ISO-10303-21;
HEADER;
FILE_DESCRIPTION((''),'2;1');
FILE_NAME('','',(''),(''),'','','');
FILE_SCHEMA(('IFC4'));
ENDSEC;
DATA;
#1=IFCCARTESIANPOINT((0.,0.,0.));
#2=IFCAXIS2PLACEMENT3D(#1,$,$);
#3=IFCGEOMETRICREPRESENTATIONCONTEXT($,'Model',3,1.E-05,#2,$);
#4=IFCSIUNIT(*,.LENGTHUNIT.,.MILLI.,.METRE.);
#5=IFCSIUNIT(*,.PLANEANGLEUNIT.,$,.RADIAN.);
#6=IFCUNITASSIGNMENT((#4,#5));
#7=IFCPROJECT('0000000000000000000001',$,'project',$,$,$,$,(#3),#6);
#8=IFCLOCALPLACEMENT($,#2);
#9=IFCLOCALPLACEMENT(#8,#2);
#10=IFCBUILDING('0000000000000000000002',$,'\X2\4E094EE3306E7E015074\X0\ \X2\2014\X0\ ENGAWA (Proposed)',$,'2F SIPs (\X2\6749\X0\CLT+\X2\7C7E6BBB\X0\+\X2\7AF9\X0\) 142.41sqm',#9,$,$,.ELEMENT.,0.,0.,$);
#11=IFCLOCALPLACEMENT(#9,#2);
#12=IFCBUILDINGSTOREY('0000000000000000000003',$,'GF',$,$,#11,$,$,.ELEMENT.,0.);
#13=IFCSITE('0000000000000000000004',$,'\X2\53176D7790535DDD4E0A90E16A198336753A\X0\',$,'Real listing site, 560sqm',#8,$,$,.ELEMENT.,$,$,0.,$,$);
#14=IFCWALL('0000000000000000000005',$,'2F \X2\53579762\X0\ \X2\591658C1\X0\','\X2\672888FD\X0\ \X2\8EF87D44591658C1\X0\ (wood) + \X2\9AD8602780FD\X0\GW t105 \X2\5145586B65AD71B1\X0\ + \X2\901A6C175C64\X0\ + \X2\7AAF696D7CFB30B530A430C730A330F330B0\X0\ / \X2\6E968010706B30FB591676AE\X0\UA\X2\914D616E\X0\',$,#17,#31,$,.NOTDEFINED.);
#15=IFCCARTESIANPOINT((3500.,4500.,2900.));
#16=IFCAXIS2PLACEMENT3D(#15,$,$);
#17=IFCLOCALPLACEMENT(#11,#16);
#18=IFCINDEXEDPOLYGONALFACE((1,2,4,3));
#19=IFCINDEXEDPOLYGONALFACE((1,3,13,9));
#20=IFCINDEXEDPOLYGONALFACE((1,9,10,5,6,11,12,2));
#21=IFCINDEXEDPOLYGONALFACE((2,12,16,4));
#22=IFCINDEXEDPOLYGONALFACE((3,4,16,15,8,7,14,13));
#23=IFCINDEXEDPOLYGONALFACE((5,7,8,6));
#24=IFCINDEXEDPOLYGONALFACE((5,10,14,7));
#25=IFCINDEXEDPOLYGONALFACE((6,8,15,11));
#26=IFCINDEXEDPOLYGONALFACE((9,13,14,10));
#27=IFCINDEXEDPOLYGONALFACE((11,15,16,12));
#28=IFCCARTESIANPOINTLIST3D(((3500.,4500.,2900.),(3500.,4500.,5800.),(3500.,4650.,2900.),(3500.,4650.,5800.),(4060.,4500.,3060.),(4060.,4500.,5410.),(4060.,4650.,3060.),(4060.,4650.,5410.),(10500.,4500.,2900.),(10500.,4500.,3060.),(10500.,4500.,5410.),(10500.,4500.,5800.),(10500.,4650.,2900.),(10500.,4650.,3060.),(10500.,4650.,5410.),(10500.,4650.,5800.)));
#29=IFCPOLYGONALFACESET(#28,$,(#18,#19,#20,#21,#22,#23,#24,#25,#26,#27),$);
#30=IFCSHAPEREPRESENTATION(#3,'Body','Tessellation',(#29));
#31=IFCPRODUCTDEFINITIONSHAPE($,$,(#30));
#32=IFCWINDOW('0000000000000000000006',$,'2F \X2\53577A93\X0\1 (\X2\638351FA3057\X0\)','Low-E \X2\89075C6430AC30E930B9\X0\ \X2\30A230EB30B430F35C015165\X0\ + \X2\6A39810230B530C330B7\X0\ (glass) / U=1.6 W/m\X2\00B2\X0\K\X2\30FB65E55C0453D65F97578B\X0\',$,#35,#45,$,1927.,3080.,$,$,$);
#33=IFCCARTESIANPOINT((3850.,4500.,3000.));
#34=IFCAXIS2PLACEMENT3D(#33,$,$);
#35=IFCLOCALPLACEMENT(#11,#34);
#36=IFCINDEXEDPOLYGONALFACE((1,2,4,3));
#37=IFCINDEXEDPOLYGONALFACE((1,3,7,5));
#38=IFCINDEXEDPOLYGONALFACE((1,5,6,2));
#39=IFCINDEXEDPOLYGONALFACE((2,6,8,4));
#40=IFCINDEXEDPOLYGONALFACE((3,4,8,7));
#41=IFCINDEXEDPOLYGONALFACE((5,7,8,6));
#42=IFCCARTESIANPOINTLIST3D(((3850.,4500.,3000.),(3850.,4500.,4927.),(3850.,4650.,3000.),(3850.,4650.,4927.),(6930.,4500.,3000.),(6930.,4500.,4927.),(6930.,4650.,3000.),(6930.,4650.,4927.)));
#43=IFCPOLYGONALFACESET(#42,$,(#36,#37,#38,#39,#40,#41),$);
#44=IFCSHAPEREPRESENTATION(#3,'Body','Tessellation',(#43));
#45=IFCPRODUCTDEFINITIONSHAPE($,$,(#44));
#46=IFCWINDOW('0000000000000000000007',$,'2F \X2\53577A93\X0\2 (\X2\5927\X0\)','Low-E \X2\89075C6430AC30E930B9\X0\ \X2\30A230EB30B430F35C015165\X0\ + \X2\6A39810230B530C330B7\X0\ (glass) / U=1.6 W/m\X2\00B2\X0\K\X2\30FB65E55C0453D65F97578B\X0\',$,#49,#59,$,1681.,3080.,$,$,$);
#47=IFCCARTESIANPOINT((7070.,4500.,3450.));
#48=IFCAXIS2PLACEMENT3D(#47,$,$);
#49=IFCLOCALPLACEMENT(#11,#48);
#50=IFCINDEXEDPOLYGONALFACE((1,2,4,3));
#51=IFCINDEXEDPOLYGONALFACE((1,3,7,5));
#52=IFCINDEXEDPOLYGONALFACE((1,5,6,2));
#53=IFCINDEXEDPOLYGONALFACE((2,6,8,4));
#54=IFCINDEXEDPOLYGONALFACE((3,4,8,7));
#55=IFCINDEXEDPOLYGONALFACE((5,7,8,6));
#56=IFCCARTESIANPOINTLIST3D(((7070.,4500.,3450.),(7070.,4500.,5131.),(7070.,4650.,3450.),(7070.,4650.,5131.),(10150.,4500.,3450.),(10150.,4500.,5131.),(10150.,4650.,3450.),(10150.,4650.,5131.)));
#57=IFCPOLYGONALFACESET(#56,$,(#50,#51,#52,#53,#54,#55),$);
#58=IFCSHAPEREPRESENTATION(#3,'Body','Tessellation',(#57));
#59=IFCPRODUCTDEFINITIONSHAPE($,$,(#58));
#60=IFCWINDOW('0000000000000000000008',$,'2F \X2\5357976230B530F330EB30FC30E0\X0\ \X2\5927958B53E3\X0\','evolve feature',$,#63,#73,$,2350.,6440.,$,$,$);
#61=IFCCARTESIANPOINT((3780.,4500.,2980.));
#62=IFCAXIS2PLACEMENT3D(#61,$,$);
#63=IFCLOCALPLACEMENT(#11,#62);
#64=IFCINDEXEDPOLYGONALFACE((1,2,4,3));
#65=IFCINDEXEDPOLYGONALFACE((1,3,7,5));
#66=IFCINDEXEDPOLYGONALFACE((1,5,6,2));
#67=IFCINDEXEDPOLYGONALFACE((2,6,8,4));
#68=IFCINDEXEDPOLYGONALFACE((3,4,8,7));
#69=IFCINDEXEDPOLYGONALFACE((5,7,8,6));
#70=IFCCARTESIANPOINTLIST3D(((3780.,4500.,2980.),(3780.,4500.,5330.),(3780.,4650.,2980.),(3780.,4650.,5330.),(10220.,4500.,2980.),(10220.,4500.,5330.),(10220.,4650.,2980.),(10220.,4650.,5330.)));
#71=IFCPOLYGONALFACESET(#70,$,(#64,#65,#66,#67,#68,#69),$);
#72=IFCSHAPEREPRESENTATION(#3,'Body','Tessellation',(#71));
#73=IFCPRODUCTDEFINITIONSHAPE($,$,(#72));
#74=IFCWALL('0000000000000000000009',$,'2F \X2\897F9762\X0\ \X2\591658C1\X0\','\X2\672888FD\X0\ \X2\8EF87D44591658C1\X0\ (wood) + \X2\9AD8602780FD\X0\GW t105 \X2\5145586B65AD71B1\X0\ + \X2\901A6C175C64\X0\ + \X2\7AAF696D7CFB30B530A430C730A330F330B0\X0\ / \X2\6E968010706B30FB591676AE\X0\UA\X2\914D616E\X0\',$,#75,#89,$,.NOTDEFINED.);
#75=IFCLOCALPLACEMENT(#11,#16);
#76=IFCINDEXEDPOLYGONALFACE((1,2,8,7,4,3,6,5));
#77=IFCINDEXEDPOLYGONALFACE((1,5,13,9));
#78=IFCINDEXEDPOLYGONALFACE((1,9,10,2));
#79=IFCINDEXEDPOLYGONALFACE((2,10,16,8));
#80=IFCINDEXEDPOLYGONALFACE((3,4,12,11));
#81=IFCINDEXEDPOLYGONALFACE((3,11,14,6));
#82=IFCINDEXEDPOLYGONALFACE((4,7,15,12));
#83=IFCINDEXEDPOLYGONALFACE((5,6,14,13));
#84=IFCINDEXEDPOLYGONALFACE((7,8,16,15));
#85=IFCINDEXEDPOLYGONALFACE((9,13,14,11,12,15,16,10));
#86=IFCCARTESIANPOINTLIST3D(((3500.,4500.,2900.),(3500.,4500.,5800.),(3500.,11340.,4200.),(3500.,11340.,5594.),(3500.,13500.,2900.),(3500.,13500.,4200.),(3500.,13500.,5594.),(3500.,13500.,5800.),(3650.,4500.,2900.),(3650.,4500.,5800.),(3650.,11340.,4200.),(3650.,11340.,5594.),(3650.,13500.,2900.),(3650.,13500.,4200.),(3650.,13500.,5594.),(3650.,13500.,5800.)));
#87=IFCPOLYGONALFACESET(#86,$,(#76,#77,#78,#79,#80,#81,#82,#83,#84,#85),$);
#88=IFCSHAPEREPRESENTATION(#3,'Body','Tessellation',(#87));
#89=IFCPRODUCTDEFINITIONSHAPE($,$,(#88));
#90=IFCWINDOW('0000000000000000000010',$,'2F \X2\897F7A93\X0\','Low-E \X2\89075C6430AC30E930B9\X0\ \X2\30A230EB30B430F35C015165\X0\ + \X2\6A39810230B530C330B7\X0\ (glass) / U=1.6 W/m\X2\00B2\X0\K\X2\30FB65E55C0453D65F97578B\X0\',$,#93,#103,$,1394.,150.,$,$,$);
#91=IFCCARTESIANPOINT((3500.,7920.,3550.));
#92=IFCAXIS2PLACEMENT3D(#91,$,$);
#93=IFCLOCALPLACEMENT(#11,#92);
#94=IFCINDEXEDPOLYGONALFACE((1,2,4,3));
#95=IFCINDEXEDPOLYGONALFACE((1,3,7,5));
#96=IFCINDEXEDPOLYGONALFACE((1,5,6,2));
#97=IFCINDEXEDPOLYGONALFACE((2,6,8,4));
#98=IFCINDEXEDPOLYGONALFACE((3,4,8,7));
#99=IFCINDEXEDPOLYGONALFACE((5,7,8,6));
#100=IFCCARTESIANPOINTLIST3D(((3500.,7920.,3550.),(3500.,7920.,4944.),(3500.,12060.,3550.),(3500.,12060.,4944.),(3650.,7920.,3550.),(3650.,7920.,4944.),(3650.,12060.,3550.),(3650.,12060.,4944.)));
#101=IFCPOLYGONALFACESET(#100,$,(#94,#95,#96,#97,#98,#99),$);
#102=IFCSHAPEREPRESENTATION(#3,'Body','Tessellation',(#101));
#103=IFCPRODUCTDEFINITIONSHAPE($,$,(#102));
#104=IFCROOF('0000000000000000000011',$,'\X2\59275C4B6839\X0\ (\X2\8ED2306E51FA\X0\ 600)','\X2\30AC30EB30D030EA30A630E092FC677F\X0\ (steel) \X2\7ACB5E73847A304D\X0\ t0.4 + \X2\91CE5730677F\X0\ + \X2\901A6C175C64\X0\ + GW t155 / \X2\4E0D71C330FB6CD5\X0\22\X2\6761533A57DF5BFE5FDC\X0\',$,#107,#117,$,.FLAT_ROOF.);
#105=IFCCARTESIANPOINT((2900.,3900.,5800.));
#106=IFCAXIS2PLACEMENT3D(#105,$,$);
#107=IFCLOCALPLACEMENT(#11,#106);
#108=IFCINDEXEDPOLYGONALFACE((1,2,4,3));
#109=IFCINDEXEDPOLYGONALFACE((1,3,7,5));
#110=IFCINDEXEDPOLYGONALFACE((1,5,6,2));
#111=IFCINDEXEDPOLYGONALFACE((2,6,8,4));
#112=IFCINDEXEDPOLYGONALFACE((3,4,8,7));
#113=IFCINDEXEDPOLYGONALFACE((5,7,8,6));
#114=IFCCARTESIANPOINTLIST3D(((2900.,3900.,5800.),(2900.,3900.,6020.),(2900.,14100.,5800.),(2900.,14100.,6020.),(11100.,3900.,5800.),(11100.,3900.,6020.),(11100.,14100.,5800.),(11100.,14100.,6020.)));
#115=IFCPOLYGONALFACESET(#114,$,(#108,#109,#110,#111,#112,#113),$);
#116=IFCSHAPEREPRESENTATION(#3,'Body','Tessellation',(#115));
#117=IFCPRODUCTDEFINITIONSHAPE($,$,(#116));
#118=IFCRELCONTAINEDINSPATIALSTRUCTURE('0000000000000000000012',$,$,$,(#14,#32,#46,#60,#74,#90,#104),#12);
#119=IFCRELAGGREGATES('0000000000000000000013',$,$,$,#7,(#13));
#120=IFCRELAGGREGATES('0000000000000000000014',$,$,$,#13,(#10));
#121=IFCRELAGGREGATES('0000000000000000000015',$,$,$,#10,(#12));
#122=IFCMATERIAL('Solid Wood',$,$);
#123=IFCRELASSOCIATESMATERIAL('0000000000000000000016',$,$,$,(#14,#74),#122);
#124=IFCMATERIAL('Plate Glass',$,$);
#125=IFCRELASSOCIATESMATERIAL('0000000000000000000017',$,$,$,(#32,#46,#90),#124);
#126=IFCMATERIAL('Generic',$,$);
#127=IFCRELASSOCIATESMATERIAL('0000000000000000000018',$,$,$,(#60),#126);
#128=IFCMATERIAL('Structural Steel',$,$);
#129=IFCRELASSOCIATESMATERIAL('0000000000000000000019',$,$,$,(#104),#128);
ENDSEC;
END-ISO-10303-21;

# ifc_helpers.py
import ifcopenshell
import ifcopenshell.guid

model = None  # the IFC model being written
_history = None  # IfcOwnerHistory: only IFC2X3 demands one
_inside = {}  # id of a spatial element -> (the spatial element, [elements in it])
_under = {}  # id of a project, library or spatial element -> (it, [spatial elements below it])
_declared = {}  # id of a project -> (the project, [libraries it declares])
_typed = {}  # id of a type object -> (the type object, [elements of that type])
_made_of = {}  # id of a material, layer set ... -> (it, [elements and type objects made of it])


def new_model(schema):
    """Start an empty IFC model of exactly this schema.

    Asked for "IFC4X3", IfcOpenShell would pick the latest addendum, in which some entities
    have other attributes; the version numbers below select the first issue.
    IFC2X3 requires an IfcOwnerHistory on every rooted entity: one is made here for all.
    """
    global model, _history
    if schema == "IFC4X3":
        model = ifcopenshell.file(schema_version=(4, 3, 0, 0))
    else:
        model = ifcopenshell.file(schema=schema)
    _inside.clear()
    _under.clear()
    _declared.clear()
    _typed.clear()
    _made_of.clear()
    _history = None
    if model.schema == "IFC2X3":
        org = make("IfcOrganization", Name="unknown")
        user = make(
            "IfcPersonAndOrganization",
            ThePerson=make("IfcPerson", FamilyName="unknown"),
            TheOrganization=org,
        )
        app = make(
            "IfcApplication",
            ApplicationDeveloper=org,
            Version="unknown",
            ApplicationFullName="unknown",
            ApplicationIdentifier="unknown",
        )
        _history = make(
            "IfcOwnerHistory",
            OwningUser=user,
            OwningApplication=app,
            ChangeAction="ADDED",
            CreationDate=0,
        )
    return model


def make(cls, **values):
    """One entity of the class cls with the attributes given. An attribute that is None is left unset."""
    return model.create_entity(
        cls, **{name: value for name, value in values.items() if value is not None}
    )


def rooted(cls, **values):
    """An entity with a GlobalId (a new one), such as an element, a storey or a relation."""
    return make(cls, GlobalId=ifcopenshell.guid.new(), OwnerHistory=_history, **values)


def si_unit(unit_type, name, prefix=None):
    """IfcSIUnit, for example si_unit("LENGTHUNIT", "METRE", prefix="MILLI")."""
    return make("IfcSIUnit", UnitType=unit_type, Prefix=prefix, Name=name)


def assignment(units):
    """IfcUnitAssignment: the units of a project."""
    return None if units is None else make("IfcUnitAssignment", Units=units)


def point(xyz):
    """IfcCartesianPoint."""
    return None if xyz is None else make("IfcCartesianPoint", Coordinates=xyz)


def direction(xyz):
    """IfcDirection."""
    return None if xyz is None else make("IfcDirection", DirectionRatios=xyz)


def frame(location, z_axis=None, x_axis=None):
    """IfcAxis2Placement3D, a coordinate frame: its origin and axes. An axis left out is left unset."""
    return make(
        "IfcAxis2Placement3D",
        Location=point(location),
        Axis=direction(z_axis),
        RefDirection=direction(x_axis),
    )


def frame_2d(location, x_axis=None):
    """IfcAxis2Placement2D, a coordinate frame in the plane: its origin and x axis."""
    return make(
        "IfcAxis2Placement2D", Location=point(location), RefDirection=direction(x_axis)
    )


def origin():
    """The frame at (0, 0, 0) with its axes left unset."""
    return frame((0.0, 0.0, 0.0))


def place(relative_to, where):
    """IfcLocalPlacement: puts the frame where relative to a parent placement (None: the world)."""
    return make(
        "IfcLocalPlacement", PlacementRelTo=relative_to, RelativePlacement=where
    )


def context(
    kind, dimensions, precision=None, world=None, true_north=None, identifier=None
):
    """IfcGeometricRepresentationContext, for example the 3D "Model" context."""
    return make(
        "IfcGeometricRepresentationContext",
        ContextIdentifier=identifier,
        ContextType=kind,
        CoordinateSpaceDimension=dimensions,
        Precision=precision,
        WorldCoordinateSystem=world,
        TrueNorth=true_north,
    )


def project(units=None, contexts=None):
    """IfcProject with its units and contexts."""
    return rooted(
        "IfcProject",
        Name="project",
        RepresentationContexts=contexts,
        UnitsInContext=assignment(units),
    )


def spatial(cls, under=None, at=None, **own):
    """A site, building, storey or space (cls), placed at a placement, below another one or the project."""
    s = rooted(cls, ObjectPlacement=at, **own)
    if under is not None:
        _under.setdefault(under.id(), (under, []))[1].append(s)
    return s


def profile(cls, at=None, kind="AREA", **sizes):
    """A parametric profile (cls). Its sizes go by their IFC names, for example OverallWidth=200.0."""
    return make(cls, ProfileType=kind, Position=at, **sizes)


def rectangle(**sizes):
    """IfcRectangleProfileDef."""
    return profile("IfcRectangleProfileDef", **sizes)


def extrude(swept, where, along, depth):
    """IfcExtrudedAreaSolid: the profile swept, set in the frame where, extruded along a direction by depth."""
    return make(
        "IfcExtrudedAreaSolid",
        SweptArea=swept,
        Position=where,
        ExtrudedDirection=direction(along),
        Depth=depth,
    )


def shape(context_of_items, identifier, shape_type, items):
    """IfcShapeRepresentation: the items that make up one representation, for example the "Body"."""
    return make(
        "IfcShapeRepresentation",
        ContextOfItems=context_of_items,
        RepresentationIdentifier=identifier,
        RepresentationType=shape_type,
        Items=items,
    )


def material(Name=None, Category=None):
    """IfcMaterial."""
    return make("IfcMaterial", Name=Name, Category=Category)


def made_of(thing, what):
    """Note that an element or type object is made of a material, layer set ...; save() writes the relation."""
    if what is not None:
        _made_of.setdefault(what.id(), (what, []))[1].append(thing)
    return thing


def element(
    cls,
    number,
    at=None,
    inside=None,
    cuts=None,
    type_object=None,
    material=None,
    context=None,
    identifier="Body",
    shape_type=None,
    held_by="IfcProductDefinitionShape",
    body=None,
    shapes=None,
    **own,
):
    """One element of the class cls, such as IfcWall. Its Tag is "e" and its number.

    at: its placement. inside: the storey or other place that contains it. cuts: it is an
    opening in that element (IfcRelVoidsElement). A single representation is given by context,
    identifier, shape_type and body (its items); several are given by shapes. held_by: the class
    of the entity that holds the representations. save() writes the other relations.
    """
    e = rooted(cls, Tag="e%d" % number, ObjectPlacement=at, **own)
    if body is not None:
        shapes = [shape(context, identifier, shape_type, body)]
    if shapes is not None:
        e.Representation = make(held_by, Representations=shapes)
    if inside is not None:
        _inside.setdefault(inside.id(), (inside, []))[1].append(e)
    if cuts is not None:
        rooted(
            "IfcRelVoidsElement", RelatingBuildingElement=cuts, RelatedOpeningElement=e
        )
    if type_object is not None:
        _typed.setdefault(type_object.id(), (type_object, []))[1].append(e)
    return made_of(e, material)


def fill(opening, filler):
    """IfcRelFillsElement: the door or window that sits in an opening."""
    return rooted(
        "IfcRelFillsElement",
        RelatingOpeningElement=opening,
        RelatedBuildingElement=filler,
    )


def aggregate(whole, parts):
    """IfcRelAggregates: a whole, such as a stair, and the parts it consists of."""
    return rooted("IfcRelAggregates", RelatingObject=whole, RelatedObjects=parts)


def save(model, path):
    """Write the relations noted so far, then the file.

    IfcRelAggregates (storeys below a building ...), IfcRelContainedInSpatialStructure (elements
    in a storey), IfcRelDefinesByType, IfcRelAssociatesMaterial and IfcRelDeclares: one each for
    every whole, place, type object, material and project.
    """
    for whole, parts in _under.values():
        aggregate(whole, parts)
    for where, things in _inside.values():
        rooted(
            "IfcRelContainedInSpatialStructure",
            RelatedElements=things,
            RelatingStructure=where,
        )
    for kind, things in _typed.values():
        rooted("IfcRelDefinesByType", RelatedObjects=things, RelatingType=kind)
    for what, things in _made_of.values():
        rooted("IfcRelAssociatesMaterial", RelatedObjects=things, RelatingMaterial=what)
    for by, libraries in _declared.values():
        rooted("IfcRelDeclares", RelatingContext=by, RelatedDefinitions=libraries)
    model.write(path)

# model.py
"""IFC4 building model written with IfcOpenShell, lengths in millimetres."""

from ifc_helpers import new_model, si_unit, frame, frame_2d, origin, place, context, project, spatial, rectangle, extrude, material, element, fill, save


model = new_model("IFC4")

# Units and contexts
model_context = context("Model", 3, precision=1e-05, world=origin())
ifc_project = project(units=[si_unit("LENGTHUNIT", "METRE", prefix="MILLI"), si_unit("PLANEANGLEUNIT", "RADIAN")], contexts=[model_context])

# Site, building, storey
site_placement = place(None, origin())
site = spatial("IfcSite", under=ifc_project, at=site_placement, Name="北海道川上郡標茶町", ObjectType="Real listing site, 560sqm", CompositionType="ELEMENT", RefElevation=0.0)
building_placement = place(site_placement, origin())
building = spatial("IfcBuilding", under=site, at=building_placement, Name="三代の縁側 — ENGAWA (Proposed)", ObjectType="2F SIPs (杉CLT+籾殻+竹) 142.41sqm", CompositionType="ELEMENT", ElevationOfRefHeight=0.0, ElevationOfTerrain=0.0)
storey_placement = place(building_placement, origin())
storey = spatial("IfcBuildingStorey", under=building, at=storey_placement, Name="GF", CompositionType="ELEMENT", Elevation=0.0)

# Shared definitions
ifc_material_1 = material(Name="Solid Wood")
ifc_material_2 = material(Name="Generic")

# Shared definitions
ifc_material_3 = material(Name="Plate Glass")

# Wall, openings, windows
wall_1_placement = place(storey_placement, frame((3500.0, 4500.0, 2900.0)))
wall_1 = element("IfcWall", 1, at=wall_1_placement, inside=storey, material=ifc_material_1, Name="2F 南面 外壁", Description="木製 軸組外壁 (wood) + 高性能GW t105 充填断熱 + 通気層 + 窯業系サイディング / 準耐火・外皮UA配慮", PredefinedType="NOTDEFINED", context=model_context, shape_type="SweptSolid", body=[
    extrude(rectangle(XDim=7000.0, YDim=150.0, at=frame_2d((3500.0, 75.0))), frame((3500.0, 4500.0, 2900.0)), (0.0, 0.0, 1.0), 2900.0),
])
opening_1_placement = place(storey_placement, frame((3850.0, 4500.0, 3000.0)))
opening_1 = element("IfcOpeningElement", 2, at=opening_1_placement, cuts=wall_1, PredefinedType="NOTDEFINED", context=model_context, shape_type="SweptSolid", body=[
    extrude(rectangle(XDim=3080.0, YDim=150.0, at=frame_2d((1540.0, 75.0))), frame((3850.0, 4500.0, 3000.0)), (0.0, 0.0, 1.0), 1927.0),
])
opening_2_placement = place(storey_placement, frame((7070.0, 4500.0, 3450.0)))
opening_2 = element("IfcOpeningElement", 3, at=opening_2_placement, cuts=wall_1, PredefinedType="NOTDEFINED", context=model_context, shape_type="SweptSolid", body=[
    extrude(rectangle(XDim=3080.0, YDim=150.0, at=frame_2d((1540.0, 75.0))), frame((7070.0, 4500.0, 3450.0)), (0.0, 0.0, 1.0), 1681.0),
])
opening_3_placement = place(storey_placement, frame((3780.0, 4500.0, 2980.0)))
opening_3 = element("IfcOpeningElement", 4, at=opening_3_placement, cuts=wall_1, PredefinedType="NOTDEFINED", context=model_context, shape_type="SweptSolid", body=[
    extrude(rectangle(XDim=6440.0, YDim=150.0, at=frame_2d((3220.0, 75.0))), frame((3780.0, 4500.0, 2980.0)), (0.0, 0.0, 1.0), 2350.0),
])
window_1_placement = place(storey_placement, frame((3850.0, 4500.0, 3000.0)))
window_1 = element("IfcWindow", 5, at=window_1_placement, inside=storey, material=ifc_material_3, Name="2F 南窓1 (掃出し)", Description="Low-E 複層ガラス アルゴン封入 + 樹脂サッシ (glass) / U=1.6 W/m²K・日射取得型", OverallHeight=1927.0, OverallWidth=3080.0, context=model_context, shape_type="SweptSolid", body=[
    extrude(rectangle(XDim=3080.0, YDim=150.0, at=frame_2d((1540.0, 75.0))), frame((3850.0, 4500.0, 3000.0)), (0.0, 0.0, 1.0), 1927.0),
])
fill(opening_1, window_1)
window_2_placement = place(storey_placement, frame((7070.0, 4500.0, 3450.0)))
window_2 = element("IfcWindow", 6, at=window_2_placement, inside=storey, material=ifc_material_3, Name="2F 南窓2 (大)", Description="Low-E 複層ガラス アルゴン封入 + 樹脂サッシ (glass) / U=1.6 W/m²K・日射取得型", OverallHeight=1681.0, OverallWidth=3080.0, context=model_context, shape_type="SweptSolid", body=[
    extrude(rectangle(XDim=3080.0, YDim=150.0, at=frame_2d((1540.0, 75.0))), frame((7070.0, 4500.0, 3450.0)), (0.0, 0.0, 1.0), 1681.0),
])
fill(opening_2, window_2)
window_3_placement = place(storey_placement, frame((3780.0, 4500.0, 2980.0)))
window_3 = element("IfcWindow", 7, at=window_3_placement, inside=storey, material=ifc_material_2, Name="2F 南面サンルーム 大開口", Description="evolve feature", OverallHeight=2350.0, OverallWidth=6440.0, context=model_context, shape_type="SweptSolid", body=[
    extrude(rectangle(XDim=6440.0, YDim=150.0, at=frame_2d((3220.0, 75.0))), frame((3780.0, 4500.0, 2980.0)), (0.0, 0.0, 1.0), 2350.0),
])
fill(opening_3, window_3)

# Wall, opening, window
wall_2_placement = place(storey_placement, frame((3500.0, 4500.0, 2900.0)))
wall_2 = element("IfcWall", 8, at=wall_2_placement, inside=storey, material=ifc_material_1, Name="2F 西面 外壁", Description="木製 軸組外壁 (wood) + 高性能GW t105 充填断熱 + 通気層 + 窯業系サイディング / 準耐火・外皮UA配慮", PredefinedType="NOTDEFINED", context=model_context, shape_type="SweptSolid", body=[
    extrude(rectangle(XDim=150.0, YDim=9000.0, at=frame_2d((75.0, 4500.0))), frame((3500.0, 4500.0, 2900.0)), (0.0, 0.0, 1.0), 2900.0),
])
opening_4_placement = place(storey_placement, frame((3500.0, 7920.0, 3550.0)))
opening_4 = element("IfcOpeningElement", 9, at=opening_4_placement, cuts=wall_2, PredefinedType="NOTDEFINED", context=model_context, shape_type="SweptSolid", body=[
    extrude(rectangle(XDim=150.0, YDim=4140.0, at=frame_2d((75.0, 2070.0))), frame((3500.0, 7920.0, 3550.0)), (0.0, 0.0, 1.0), 1394.0),
])
window_4_placement = place(storey_placement, frame((3500.0, 7920.0, 3550.0)))
window_4 = element("IfcWindow", 10, at=window_4_placement, inside=storey, material=ifc_material_3, Name="2F 西窓", Description="Low-E 複層ガラス アルゴン封入 + 樹脂サッシ (glass) / U=1.6 W/m²K・日射取得型", OverallHeight=1394.0, OverallWidth=150.0, context=model_context, shape_type="SweptSolid", body=[
    extrude(rectangle(XDim=150.0, YDim=4140.0, at=frame_2d((75.0, 2070.0))), frame((3500.0, 7920.0, 3550.0)), (0.0, 0.0, 1.0), 1394.0),
])
fill(opening_4, window_4)

# Roof
ifc_material_4 = material(Name="Structural Steel")
roof_placement = place(storey_placement, frame((2900.0, 3900.0, 5800.0)))
element("IfcRoof", 11, at=roof_placement, inside=storey, material=ifc_material_4, Name="大屋根 (軒の出 600)", Description="ガルバリウム鋼板 (steel) 立平葺き t0.4 + 野地板 + 通気層 + GW t155 / 不燃・法22条区域対応", PredefinedType="FLAT_ROOF", context=model_context, shape_type="SweptSolid", body=[
    extrude(rectangle(XDim=8200.0, YDim=10200.0, at=frame_2d((4100.0, 5100.0))), frame((2900.0, 3900.0, 5800.0)), (0.0, 0.0, 1.0), 220.0),
])

save(model, "model.ifc")
